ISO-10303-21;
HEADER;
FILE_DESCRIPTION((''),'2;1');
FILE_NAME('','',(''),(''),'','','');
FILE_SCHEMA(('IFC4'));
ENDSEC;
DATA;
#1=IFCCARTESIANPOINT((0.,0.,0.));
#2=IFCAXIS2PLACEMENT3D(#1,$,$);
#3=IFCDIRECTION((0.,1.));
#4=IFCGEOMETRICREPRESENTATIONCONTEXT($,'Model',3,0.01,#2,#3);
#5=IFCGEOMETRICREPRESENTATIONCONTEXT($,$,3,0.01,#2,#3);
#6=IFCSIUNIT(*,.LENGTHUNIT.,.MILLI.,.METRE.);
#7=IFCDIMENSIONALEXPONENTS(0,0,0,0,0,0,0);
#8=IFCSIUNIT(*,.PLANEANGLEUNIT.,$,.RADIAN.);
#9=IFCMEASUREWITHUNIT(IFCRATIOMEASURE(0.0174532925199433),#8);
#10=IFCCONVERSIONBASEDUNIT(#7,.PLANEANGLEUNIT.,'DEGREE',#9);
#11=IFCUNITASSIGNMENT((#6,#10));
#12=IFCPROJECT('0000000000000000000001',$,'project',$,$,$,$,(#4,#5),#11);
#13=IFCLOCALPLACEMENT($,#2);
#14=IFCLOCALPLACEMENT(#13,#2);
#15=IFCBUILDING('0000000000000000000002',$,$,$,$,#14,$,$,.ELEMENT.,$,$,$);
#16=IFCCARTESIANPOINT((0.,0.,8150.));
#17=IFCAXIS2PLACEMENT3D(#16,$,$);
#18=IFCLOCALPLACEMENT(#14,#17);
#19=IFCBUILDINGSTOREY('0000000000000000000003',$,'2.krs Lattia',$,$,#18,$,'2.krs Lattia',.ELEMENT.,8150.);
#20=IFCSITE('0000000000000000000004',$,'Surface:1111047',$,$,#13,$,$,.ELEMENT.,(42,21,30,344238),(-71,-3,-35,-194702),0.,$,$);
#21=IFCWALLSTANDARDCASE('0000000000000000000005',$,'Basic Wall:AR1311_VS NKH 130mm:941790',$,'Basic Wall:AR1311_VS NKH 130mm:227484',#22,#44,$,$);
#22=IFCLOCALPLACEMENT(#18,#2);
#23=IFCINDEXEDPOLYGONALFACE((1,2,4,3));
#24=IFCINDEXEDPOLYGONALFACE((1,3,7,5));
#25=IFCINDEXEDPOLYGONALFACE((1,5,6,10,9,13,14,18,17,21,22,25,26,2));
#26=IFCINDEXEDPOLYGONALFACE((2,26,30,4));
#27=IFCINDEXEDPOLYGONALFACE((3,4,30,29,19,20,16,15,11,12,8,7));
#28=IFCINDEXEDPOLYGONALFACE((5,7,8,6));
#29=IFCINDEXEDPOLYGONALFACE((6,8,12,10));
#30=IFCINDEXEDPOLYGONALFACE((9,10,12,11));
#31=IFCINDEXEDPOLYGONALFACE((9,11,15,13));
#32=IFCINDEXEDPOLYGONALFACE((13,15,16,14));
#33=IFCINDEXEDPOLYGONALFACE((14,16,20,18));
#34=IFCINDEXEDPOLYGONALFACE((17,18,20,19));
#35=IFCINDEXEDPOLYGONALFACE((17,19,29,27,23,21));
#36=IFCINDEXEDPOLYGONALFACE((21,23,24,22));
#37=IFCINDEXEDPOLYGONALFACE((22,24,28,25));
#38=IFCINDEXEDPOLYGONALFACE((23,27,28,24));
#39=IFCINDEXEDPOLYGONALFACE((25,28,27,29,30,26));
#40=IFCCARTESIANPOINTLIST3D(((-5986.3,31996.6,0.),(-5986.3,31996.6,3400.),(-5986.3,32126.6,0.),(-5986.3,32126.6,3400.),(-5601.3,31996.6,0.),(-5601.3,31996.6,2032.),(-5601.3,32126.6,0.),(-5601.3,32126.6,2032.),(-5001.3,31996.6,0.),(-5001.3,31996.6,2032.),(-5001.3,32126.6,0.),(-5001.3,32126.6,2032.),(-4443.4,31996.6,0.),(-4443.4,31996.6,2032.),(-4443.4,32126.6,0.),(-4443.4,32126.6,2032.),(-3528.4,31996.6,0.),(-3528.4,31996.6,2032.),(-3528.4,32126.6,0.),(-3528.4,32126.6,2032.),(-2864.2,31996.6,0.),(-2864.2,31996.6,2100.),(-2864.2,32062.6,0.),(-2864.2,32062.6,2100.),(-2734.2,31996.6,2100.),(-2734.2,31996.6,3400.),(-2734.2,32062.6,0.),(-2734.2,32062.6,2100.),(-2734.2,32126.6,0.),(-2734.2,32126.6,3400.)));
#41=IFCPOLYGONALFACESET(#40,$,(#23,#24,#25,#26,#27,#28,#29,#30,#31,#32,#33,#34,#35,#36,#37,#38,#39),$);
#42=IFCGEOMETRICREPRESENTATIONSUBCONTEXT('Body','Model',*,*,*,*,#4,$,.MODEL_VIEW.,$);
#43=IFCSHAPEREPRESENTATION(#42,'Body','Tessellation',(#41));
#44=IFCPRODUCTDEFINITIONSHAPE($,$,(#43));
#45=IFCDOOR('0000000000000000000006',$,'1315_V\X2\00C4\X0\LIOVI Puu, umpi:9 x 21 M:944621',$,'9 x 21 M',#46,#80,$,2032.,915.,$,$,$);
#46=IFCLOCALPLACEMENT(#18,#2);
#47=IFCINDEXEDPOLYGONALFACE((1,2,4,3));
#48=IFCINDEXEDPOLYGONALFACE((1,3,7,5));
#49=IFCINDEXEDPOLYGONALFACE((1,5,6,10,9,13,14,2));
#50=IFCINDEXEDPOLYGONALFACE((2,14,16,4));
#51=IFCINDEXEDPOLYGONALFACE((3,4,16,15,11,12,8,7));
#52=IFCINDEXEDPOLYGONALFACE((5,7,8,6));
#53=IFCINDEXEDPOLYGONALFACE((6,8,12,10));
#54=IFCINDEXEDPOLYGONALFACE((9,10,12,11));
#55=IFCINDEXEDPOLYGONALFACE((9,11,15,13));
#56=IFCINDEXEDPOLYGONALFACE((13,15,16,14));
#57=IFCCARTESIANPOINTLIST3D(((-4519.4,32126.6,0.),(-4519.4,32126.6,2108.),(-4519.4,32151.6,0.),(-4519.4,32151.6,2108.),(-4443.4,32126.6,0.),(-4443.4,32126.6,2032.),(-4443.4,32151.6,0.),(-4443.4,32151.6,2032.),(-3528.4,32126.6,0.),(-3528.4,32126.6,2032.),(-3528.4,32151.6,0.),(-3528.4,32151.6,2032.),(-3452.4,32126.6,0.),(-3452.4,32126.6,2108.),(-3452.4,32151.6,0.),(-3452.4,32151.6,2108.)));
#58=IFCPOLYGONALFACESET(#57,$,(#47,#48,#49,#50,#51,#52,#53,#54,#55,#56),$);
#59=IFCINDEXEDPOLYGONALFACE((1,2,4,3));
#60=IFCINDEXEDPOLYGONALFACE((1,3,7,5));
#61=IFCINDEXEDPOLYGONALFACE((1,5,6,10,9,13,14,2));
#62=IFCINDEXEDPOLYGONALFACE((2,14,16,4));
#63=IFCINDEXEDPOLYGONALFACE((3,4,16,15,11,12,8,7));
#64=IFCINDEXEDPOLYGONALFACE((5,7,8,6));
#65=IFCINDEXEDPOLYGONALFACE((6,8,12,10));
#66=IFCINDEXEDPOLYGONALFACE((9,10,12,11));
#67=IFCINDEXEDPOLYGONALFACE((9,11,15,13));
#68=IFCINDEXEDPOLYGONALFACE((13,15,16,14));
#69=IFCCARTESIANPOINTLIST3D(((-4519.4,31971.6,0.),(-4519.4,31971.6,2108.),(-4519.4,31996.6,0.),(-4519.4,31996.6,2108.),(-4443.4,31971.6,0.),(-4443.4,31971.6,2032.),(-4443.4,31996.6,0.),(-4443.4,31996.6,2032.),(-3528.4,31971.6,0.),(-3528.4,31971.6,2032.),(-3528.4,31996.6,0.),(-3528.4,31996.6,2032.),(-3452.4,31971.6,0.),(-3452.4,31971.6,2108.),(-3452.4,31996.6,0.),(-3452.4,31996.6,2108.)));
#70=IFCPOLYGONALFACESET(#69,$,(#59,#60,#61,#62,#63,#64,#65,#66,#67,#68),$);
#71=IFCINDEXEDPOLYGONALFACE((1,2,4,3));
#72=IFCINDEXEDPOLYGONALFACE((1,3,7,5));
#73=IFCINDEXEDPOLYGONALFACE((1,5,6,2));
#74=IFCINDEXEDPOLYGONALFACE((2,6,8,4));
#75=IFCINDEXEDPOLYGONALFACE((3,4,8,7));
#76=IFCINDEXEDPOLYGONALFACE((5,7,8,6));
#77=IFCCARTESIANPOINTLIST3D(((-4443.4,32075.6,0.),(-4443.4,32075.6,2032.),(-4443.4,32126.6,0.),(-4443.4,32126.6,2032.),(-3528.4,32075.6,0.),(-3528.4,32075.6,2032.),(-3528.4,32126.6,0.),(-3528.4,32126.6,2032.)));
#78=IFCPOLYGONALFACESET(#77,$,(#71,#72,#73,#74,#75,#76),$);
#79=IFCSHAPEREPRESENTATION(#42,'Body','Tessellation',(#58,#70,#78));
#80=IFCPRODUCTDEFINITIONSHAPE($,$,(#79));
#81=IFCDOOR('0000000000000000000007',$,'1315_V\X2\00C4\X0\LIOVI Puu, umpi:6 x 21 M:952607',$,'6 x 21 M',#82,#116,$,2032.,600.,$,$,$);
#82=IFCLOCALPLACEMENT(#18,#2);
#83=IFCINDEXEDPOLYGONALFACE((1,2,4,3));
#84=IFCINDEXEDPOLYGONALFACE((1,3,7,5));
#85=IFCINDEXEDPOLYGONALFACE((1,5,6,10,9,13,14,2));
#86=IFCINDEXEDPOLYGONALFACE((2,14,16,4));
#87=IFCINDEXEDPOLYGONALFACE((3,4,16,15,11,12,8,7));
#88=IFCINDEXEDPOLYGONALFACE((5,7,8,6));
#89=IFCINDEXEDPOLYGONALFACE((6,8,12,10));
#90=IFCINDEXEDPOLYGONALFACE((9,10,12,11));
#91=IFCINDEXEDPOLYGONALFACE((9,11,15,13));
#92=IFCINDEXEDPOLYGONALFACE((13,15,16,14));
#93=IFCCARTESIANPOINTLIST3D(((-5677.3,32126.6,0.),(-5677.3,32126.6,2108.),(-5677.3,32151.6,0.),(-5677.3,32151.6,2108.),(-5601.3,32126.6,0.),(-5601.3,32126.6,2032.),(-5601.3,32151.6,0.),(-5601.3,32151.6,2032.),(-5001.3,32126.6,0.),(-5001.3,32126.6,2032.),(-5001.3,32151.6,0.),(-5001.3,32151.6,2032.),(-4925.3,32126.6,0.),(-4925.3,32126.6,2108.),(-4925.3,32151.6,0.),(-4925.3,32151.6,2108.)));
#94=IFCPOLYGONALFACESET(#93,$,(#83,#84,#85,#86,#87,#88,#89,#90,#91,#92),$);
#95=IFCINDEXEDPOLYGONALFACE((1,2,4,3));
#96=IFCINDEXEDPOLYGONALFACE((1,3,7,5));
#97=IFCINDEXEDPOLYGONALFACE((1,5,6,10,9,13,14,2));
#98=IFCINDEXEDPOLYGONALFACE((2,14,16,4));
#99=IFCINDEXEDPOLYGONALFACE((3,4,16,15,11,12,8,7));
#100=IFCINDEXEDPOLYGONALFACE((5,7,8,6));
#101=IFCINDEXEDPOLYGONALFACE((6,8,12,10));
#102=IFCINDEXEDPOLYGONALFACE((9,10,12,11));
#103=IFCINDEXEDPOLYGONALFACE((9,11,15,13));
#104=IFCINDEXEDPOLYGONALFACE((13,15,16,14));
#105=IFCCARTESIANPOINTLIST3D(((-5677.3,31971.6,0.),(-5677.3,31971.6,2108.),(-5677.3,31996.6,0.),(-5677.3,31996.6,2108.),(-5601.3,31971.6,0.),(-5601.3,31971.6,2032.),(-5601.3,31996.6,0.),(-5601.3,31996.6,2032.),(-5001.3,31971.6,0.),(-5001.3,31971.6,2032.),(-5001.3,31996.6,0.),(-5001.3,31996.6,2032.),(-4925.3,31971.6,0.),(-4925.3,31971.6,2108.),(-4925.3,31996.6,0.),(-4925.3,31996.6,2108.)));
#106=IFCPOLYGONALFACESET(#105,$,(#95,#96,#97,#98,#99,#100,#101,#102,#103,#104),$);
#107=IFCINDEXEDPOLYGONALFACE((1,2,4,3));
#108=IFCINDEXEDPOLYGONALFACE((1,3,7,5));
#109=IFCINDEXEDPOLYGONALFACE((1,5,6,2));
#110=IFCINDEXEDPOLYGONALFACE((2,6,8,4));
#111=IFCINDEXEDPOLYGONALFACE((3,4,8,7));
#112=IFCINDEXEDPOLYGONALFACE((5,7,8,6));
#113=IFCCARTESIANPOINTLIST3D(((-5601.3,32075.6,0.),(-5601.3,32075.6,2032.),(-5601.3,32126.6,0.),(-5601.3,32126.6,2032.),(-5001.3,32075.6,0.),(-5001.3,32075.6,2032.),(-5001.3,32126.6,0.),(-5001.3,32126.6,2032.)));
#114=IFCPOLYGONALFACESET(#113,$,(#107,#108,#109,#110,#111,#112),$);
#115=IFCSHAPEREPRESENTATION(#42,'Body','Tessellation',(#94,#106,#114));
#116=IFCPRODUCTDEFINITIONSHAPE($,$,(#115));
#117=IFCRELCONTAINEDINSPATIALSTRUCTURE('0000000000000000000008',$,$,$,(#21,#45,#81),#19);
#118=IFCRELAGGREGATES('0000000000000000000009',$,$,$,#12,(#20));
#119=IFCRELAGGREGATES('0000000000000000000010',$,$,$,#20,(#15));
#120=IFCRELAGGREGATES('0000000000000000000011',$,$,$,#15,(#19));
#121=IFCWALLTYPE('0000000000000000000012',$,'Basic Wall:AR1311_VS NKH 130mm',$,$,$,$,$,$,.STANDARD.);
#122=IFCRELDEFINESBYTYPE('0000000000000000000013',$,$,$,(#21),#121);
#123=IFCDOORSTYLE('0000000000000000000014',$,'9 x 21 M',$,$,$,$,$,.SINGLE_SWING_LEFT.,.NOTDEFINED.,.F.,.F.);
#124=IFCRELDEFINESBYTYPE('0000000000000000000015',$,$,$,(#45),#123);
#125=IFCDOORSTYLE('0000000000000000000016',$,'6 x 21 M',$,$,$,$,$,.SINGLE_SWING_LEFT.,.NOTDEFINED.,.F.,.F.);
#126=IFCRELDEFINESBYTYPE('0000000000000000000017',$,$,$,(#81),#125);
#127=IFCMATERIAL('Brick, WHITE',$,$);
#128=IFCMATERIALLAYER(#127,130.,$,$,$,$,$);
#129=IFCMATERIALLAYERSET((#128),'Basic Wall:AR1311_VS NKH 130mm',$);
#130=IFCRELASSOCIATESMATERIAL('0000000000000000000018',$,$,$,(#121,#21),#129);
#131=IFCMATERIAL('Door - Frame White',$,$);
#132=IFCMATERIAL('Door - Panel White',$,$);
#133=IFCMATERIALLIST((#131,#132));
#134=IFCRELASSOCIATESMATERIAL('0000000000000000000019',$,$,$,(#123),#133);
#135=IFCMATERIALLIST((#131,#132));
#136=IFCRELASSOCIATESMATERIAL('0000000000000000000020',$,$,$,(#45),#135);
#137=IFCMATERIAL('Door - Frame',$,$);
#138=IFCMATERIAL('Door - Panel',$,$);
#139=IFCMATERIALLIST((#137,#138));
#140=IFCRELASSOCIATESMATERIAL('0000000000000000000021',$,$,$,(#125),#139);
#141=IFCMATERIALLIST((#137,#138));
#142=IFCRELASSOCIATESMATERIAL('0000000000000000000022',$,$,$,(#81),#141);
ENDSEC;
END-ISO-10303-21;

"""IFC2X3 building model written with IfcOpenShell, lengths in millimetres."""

from ifc_helpers import new_model, entity, si_unit, converted_unit, direction, frame, frame_2d, origin, place, context, subcontext, project, spatial, polyline, rectangle, outline, extrude, source, transform, mapped, material, material_list, layer, layer_set, layer_usage, type_object, type_shapes, element, fill, save


model = new_model("IFC2X3")

# Units and contexts
model_context = context("Model", 3, precision=0.01, world=origin(), true_north=direction((0.0, 1.0)))
context_of_model = context(None, 3, precision=0.01, world=origin(), true_north=direction((0.0, 1.0)))
body_context = subcontext(model_context, "Body", "Model", "MODEL_VIEW")
ifc_project = project(units=[si_unit("LENGTHUNIT", "METRE", prefix="MILLI"), converted_unit("PLANEANGLEUNIT", "DEGREE", entity("IfcRatioMeasure", 0.0174532925199433), si_unit("PLANEANGLEUNIT", "RADIAN"), dimensions=[0, 0, 0, 0, 0, 0, 0])], contexts=[model_context, context_of_model])

# Site, building, storey
site_placement = place(None, origin())
site = spatial("IfcSite", under=ifc_project, at=site_placement, Name="Surface:1111047", CompositionType="ELEMENT", RefLatitude=(42, 21, 30, 344238), RefLongitude=(-71, -3, -35, -194702), RefElevation=0.0)
building_placement = place(site_placement, origin())
building = spatial("IfcBuilding", under=site, at=building_placement, CompositionType="ELEMENT")
storey_placement = place(building_placement, frame((0.0, 0.0, 8150.0)))
storey = spatial("IfcBuildingStorey", under=building, at=storey_placement, Name="2.krs Lattia", LongName="2.krs Lattia", CompositionType="ELEMENT", Elevation=8150.0)

# Shared definitions
ifc_material_1 = material(Name="Brick, WHITE")
ifc_layer = layer(ifc_material_1, 130.0)
ifc_layer_set = layer_set([ifc_layer], Name="Basic Wall:AR1311_VS NKH 130mm")
wall_type = type_object("IfcWallType", Name="Basic Wall:AR1311_VS NKH 130mm", PredefinedType="STANDARD", material=ifc_layer_set)

# Wall, openings, doors
ifc_layer_usage_1 = layer_usage(ifc_layer_set, "AXIS2", "NEGATIVE", 65.0)
wall_1_placement = place(storey_placement, frame((-5986.3, 32061.6, 0.0)))
wall_1 = element("IfcWallStandardCase", 1, at=wall_1_placement, inside=storey, type_object=wall_type, material=ifc_layer_usage_1, Name="Basic Wall:AR1311_VS NKH 130mm:941790", ObjectType="Basic Wall:AR1311_VS NKH 130mm:227484", context=body_context, shape_type="SweptSolid", body=[
    extrude(rectangle(XDim=3252.1, YDim=130.0, at=frame_2d((1626.0, 0.0), x_axis=(-1.0, 0.0))), origin(), (0.0, 0.0, 1.0), 3400.0),
])
opening_1_placement = place(wall_1_placement, origin())
element("IfcOpeningElement", 2, at=opening_1_placement, cuts=wall_1, ObjectType="Opening", context=body_context, shape_type="SweptSolid", body=[
    extrude(rectangle(XDim=2100.0, YDim=130.0, at=frame_2d((0.0, 0.0), x_axis=(0.0, 1.0))), frame((3187.1, -1509.0, 1050.0), z_axis=(0.0, 1.0, 0.0), x_axis=(1.0, 0.0, 0.0)), (0.0, 0.0, 1.0), 1510.0),
])
opening_2_placement = place(wall_1_placement, frame((1542.9, -65.0, 0.0)))
opening_2 = element("IfcOpeningElement", 3, at=opening_2_placement, cuts=wall_1, ObjectType="Opening", context=body_context, shape_type="SweptSolid", body=[
    extrude(rectangle(XDim=915.0, YDim=2032.0, at=frame_2d((1016.0, 457.5), x_axis=(0.0, -1.0))), frame((0.0, 0.0, 0.0), z_axis=(0.0, 1.0, 0.0), x_axis=(0.0, 0.0, 1.0)), (0.0, 0.0, 1.0), 130.0),
])
opening_3_placement = place(wall_1_placement, frame((385.0, -65.0, 0.0)))
opening_3 = element("IfcOpeningElement", 4, at=opening_3_placement, cuts=wall_1, ObjectType="Opening", context=body_context, shape_type="SweptSolid", body=[
    extrude(rectangle(XDim=600.0, YDim=2032.0, at=frame_2d((1016.0, 300.0), x_axis=(0.0, -1.0))), frame((0.0, 0.0, 0.0), z_axis=(0.0, 1.0, 0.0), x_axis=(0.0, 0.0, 1.0)), (0.0, 0.0, 1.0), 130.0),
])
ifc_material_2 = material(Name="Door - Frame White")
ifc_material_3 = material(Name="Door - Panel White")
ifc_material_list_1 = material_list([ifc_material_2, ifc_material_3])
ifc_material_list_2 = material_list([ifc_material_2, ifc_material_3])
door_style_1 = type_object("IfcDoorStyle", Name="9 x 21 M", ConstructionType="NOTDEFINED", OperationType="SINGLE_SWING_LEFT", ParameterTakesPrecedence=False, Sizeable=False, material=ifc_material_list_2)
shared_shape_1 = source(origin(), body_context, "Body", "SweptSolid", [
    extrude(outline(polyline([(-533.5, -1073.0), (533.5, -1073.0), (533.5, 1035.0), (457.5, 1035.0), (457.5, -997.0), (-457.5, -997.0), (-457.5, 1035.0), (-533.5, 1035.0), (-533.5, -1073.0)])), frame((457.5, 155.0, 1035.0), z_axis=(0.0, -1.0, 0.0), x_axis=(-1.0, 0.0, 0.0)), (0.0, 0.0, 1.0), 25.0),
    extrude(outline(polyline([(-1073.0, -533.5), (1035.0, -533.5), (1035.0, -457.5), (-997.0, -457.5), (-997.0, 457.5), (1035.0, 457.5), (1035.0, 533.5), (-1073.0, 533.5), (-1073.0, -533.5)])), frame((457.5, 0.0, 1035.0), z_axis=(0.0, -1.0, 0.0), x_axis=(0.0, 0.0, -1.0)), (0.0, 0.0, 1.0), 25.0),
    extrude(rectangle(XDim=915.0, YDim=51.0, at=frame_2d((0.0, 0.0), x_axis=(1.0, 0.0))), frame((457.5, 104.5, 0.0)), (0.0, 0.0, 1.0), 2032.0),
])
type_shapes(door_style_1, [shared_shape_1])
door_1_placement = place(opening_2_placement, origin())
door_1 = element("IfcDoor", 5, at=door_1_placement, inside=storey, type_object=door_style_1, material=ifc_material_list_1, Name="1315_VÄLIOVI Puu, umpi:9 x 21 M:944621", ObjectType="9 x 21 M", OverallHeight=2032.0, OverallWidth=915.0, context=body_context, shape_type="MappedRepresentation", body=[
    mapped(shared_shape_1, transform((0.0, 0.0, 0.0), scale=1.0)),
])
fill(opening_2, door_1)
ifc_material_4 = material(Name="Door - Frame")
ifc_material_5 = material(Name="Door - Panel")
ifc_material_list_3 = material_list([ifc_material_4, ifc_material_5])
ifc_material_list_4 = material_list([ifc_material_4, ifc_material_5])
door_style_2 = type_object("IfcDoorStyle", Name="6 x 21 M", ConstructionType="NOTDEFINED", OperationType="SINGLE_SWING_LEFT", ParameterTakesPrecedence=False, Sizeable=False, material=ifc_material_list_4)
shared_shape_2 = source(origin(), body_context, "Body", "SweptSolid", [
    extrude(outline(polyline([(-376.0, -1073.0), (376.0, -1073.0), (376.0, 1035.0), (300.0, 1035.0), (300.0, -997.0), (-300.0, -997.0), (-300.0, 1035.0), (-376.0, 1035.0), (-376.0, -1073.0)])), frame((300.0, 155.0, 1035.0), z_axis=(0.0, -1.0, 0.0), x_axis=(-1.0, 0.0, 0.0)), (0.0, 0.0, 1.0), 25.0),
    extrude(outline(polyline([(-1073.0, -376.0), (1035.0, -376.0), (1035.0, -300.0), (-997.0, -300.0), (-997.0, 300.0), (1035.0, 300.0), (1035.0, 376.0), (-1073.0, 376.0), (-1073.0, -376.0)])), frame((300.0, 0.0, 1035.0), z_axis=(0.0, -1.0, 0.0), x_axis=(0.0, 0.0, -1.0)), (0.0, 0.0, 1.0), 25.0),
    extrude(rectangle(XDim=600.0, YDim=51.0, at=frame_2d((0.0, 0.0), x_axis=(1.0, 0.0))), frame((300.0, 104.5, 0.0)), (0.0, 0.0, 1.0), 2032.0),
])
type_shapes(door_style_2, [shared_shape_2])
door_2_placement = place(opening_3_placement, origin())
door_2 = element("IfcDoor", 6, at=door_2_placement, inside=storey, type_object=door_style_2, material=ifc_material_list_3, Name="1315_VÄLIOVI Puu, umpi:6 x 21 M:952607", ObjectType="6 x 21 M", OverallHeight=2032.0, OverallWidth=600.0, context=body_context, shape_type="MappedRepresentation", body=[
    mapped(shared_shape_2, transform((0.0, 0.0, 0.0), scale=1.0)),
])
fill(opening_3, door_2)

save(model, "model.ifc")
